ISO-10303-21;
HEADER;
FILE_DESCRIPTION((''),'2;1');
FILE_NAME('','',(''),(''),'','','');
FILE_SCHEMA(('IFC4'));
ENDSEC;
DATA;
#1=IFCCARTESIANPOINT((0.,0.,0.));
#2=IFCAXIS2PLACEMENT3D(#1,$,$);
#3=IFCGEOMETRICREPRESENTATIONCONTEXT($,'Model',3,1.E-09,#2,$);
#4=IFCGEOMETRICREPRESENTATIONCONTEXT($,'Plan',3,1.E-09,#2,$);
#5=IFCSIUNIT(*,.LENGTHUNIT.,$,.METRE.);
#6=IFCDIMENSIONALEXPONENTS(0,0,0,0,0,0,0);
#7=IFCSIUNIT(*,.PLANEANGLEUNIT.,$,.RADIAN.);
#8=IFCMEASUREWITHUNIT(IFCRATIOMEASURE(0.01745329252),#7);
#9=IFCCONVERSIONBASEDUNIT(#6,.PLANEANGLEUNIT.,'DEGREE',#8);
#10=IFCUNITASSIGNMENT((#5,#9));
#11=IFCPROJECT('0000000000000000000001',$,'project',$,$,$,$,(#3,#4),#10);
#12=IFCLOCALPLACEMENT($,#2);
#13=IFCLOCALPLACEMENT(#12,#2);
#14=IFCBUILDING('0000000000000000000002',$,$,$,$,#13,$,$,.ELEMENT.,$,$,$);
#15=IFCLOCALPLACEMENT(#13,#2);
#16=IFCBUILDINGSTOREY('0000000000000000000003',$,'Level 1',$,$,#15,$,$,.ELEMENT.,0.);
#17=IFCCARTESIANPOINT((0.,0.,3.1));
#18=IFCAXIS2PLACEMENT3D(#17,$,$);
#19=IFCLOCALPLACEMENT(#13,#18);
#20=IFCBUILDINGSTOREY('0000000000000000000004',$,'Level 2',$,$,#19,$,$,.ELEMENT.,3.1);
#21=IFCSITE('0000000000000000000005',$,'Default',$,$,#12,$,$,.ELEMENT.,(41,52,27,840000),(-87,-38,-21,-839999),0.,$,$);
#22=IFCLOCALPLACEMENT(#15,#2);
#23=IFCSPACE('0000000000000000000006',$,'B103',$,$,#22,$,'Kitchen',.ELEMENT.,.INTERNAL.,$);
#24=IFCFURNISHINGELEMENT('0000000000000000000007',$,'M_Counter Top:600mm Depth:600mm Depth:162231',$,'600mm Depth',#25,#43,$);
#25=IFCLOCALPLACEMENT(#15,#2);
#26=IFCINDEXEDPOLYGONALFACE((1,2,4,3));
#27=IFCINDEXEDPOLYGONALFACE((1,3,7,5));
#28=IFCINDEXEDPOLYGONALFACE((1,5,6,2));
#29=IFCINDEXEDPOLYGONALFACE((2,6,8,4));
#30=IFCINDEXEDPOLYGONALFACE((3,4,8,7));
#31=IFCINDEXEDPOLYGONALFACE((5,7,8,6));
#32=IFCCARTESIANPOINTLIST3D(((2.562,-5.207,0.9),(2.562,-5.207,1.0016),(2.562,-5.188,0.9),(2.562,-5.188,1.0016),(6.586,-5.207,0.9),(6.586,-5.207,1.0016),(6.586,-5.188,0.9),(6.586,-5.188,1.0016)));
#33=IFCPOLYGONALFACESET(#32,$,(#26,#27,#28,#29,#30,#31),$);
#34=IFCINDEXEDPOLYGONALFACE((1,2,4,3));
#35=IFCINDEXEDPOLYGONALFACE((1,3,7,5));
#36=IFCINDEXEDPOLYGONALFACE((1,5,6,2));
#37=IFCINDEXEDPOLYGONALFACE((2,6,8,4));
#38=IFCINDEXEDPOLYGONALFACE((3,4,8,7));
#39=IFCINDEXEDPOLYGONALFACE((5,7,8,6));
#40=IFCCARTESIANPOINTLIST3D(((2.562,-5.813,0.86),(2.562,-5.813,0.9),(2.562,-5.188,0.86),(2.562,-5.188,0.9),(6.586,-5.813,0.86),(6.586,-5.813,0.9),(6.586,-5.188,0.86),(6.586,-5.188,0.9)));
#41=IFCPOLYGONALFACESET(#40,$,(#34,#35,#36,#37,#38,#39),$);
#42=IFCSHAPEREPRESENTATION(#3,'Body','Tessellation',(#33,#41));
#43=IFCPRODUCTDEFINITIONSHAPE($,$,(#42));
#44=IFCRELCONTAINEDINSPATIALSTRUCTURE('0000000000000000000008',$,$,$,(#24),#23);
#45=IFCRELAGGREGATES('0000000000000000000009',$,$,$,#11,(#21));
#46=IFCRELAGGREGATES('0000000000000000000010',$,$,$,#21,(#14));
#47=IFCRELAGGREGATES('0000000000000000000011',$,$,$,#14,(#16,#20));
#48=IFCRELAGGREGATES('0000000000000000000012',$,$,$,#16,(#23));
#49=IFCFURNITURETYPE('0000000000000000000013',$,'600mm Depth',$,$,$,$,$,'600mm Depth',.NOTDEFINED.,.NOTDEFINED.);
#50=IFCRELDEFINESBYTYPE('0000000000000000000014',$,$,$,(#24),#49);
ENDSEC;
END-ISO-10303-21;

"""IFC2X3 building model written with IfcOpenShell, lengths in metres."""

from ifc_helpers import new_model, entity, si_unit, converted_unit, frame, origin, origin_2d_with_axis, place, context, project, spatial, rectangle, extrude, source, transform, mapped, type_object, type_shapes, element, save


model = new_model("IFC2X3")

# Units and contexts
model_context = context("Model", 3, precision=1e-09, world=origin())
plan_context = context("Plan", 3, precision=1e-09, world=origin())
ifc_project = project(units=[si_unit("LENGTHUNIT", "METRE"), converted_unit("PLANEANGLEUNIT", "DEGREE", entity("IfcRatioMeasure", 0.01745329252), si_unit("PLANEANGLEUNIT", "RADIAN"), dimensions=[0, 0, 0, 0, 0, 0, 0])], contexts=[model_context, plan_context])

# Site, building, storey
site_placement = place(None, origin())
site = spatial("IfcSite", under=ifc_project, at=site_placement, Name="Default", CompositionType="ELEMENT", RefLatitude=(41, 52, 27, 840000), RefLongitude=(-87, -38, -21, -839999), RefElevation=0.0)
building_placement = place(site_placement, origin())
building = spatial("IfcBuilding", under=site, at=building_placement, CompositionType="ELEMENT")
storey_1_placement = place(building_placement, origin())
storey_1 = spatial("IfcBuildingStorey", under=building, at=storey_1_placement, Name="Level 1", CompositionType="ELEMENT", Elevation=0.0)

# Shared definitions
storey_2_placement = place(building_placement, frame((0.0, 0.0, 3.1)))
storey_2 = spatial("IfcBuildingStorey", under=building, at=storey_2_placement, Name="Level 2", CompositionType="ELEMENT", Elevation=3.1)

# Shared definitions
space_1_placement = place(storey_1_placement, origin())
space_1 = spatial("IfcSpace", under=storey_1, at=space_1_placement, Name="B103", LongName="Kitchen", CompositionType="ELEMENT", InteriorOrExteriorSpace="INTERNAL")

# Furnishing element
furniture_type_1 = type_object("IfcFurnitureType", Name="600mm Depth", ElementType="600mm Depth", AssemblyPlace="NOTDEFINED")
shared_shape_1 = source(origin(), model_context, "Body", "SweptSolid", [
    extrude(rectangle(XDim=0.0191, YDim=4.024, at=origin_2d_with_axis()), frame((0.8115, -0.0095, 0.9), z_axis=(0.0, 0.0, 1.0), x_axis=(0.0, -1.0, 0.0)), (0.0, 0.0, 1.0), 0.1016),
    extrude(rectangle(XDim=4.024, YDim=0.625, at=origin_2d_with_axis()), frame((0.8115, -0.3125, 0.86), z_axis=(0.0, 0.0, 1.0), x_axis=(-1.0, 0.0, 0.0)), (0.0, 0.0, 1.0), 0.04),
])
type_shapes(furniture_type_1, [shared_shape_1])
furnishing_1_placement = place(space_1_placement, frame((3.7625, -5.188, 0.0)))
element("IfcFurnishingElement", 1, at=furnishing_1_placement, inside=space_1, type_object=furniture_type_1, Name="M_Counter Top:600mm Depth:600mm Depth:162231", ObjectType="600mm Depth", context=model_context, shape_type="MappedRepresentation", body=[
    mapped(shared_shape_1, transform((0.0, 0.0, 0.0), scale=1.0)),
])

save(model, "model.ifc")
